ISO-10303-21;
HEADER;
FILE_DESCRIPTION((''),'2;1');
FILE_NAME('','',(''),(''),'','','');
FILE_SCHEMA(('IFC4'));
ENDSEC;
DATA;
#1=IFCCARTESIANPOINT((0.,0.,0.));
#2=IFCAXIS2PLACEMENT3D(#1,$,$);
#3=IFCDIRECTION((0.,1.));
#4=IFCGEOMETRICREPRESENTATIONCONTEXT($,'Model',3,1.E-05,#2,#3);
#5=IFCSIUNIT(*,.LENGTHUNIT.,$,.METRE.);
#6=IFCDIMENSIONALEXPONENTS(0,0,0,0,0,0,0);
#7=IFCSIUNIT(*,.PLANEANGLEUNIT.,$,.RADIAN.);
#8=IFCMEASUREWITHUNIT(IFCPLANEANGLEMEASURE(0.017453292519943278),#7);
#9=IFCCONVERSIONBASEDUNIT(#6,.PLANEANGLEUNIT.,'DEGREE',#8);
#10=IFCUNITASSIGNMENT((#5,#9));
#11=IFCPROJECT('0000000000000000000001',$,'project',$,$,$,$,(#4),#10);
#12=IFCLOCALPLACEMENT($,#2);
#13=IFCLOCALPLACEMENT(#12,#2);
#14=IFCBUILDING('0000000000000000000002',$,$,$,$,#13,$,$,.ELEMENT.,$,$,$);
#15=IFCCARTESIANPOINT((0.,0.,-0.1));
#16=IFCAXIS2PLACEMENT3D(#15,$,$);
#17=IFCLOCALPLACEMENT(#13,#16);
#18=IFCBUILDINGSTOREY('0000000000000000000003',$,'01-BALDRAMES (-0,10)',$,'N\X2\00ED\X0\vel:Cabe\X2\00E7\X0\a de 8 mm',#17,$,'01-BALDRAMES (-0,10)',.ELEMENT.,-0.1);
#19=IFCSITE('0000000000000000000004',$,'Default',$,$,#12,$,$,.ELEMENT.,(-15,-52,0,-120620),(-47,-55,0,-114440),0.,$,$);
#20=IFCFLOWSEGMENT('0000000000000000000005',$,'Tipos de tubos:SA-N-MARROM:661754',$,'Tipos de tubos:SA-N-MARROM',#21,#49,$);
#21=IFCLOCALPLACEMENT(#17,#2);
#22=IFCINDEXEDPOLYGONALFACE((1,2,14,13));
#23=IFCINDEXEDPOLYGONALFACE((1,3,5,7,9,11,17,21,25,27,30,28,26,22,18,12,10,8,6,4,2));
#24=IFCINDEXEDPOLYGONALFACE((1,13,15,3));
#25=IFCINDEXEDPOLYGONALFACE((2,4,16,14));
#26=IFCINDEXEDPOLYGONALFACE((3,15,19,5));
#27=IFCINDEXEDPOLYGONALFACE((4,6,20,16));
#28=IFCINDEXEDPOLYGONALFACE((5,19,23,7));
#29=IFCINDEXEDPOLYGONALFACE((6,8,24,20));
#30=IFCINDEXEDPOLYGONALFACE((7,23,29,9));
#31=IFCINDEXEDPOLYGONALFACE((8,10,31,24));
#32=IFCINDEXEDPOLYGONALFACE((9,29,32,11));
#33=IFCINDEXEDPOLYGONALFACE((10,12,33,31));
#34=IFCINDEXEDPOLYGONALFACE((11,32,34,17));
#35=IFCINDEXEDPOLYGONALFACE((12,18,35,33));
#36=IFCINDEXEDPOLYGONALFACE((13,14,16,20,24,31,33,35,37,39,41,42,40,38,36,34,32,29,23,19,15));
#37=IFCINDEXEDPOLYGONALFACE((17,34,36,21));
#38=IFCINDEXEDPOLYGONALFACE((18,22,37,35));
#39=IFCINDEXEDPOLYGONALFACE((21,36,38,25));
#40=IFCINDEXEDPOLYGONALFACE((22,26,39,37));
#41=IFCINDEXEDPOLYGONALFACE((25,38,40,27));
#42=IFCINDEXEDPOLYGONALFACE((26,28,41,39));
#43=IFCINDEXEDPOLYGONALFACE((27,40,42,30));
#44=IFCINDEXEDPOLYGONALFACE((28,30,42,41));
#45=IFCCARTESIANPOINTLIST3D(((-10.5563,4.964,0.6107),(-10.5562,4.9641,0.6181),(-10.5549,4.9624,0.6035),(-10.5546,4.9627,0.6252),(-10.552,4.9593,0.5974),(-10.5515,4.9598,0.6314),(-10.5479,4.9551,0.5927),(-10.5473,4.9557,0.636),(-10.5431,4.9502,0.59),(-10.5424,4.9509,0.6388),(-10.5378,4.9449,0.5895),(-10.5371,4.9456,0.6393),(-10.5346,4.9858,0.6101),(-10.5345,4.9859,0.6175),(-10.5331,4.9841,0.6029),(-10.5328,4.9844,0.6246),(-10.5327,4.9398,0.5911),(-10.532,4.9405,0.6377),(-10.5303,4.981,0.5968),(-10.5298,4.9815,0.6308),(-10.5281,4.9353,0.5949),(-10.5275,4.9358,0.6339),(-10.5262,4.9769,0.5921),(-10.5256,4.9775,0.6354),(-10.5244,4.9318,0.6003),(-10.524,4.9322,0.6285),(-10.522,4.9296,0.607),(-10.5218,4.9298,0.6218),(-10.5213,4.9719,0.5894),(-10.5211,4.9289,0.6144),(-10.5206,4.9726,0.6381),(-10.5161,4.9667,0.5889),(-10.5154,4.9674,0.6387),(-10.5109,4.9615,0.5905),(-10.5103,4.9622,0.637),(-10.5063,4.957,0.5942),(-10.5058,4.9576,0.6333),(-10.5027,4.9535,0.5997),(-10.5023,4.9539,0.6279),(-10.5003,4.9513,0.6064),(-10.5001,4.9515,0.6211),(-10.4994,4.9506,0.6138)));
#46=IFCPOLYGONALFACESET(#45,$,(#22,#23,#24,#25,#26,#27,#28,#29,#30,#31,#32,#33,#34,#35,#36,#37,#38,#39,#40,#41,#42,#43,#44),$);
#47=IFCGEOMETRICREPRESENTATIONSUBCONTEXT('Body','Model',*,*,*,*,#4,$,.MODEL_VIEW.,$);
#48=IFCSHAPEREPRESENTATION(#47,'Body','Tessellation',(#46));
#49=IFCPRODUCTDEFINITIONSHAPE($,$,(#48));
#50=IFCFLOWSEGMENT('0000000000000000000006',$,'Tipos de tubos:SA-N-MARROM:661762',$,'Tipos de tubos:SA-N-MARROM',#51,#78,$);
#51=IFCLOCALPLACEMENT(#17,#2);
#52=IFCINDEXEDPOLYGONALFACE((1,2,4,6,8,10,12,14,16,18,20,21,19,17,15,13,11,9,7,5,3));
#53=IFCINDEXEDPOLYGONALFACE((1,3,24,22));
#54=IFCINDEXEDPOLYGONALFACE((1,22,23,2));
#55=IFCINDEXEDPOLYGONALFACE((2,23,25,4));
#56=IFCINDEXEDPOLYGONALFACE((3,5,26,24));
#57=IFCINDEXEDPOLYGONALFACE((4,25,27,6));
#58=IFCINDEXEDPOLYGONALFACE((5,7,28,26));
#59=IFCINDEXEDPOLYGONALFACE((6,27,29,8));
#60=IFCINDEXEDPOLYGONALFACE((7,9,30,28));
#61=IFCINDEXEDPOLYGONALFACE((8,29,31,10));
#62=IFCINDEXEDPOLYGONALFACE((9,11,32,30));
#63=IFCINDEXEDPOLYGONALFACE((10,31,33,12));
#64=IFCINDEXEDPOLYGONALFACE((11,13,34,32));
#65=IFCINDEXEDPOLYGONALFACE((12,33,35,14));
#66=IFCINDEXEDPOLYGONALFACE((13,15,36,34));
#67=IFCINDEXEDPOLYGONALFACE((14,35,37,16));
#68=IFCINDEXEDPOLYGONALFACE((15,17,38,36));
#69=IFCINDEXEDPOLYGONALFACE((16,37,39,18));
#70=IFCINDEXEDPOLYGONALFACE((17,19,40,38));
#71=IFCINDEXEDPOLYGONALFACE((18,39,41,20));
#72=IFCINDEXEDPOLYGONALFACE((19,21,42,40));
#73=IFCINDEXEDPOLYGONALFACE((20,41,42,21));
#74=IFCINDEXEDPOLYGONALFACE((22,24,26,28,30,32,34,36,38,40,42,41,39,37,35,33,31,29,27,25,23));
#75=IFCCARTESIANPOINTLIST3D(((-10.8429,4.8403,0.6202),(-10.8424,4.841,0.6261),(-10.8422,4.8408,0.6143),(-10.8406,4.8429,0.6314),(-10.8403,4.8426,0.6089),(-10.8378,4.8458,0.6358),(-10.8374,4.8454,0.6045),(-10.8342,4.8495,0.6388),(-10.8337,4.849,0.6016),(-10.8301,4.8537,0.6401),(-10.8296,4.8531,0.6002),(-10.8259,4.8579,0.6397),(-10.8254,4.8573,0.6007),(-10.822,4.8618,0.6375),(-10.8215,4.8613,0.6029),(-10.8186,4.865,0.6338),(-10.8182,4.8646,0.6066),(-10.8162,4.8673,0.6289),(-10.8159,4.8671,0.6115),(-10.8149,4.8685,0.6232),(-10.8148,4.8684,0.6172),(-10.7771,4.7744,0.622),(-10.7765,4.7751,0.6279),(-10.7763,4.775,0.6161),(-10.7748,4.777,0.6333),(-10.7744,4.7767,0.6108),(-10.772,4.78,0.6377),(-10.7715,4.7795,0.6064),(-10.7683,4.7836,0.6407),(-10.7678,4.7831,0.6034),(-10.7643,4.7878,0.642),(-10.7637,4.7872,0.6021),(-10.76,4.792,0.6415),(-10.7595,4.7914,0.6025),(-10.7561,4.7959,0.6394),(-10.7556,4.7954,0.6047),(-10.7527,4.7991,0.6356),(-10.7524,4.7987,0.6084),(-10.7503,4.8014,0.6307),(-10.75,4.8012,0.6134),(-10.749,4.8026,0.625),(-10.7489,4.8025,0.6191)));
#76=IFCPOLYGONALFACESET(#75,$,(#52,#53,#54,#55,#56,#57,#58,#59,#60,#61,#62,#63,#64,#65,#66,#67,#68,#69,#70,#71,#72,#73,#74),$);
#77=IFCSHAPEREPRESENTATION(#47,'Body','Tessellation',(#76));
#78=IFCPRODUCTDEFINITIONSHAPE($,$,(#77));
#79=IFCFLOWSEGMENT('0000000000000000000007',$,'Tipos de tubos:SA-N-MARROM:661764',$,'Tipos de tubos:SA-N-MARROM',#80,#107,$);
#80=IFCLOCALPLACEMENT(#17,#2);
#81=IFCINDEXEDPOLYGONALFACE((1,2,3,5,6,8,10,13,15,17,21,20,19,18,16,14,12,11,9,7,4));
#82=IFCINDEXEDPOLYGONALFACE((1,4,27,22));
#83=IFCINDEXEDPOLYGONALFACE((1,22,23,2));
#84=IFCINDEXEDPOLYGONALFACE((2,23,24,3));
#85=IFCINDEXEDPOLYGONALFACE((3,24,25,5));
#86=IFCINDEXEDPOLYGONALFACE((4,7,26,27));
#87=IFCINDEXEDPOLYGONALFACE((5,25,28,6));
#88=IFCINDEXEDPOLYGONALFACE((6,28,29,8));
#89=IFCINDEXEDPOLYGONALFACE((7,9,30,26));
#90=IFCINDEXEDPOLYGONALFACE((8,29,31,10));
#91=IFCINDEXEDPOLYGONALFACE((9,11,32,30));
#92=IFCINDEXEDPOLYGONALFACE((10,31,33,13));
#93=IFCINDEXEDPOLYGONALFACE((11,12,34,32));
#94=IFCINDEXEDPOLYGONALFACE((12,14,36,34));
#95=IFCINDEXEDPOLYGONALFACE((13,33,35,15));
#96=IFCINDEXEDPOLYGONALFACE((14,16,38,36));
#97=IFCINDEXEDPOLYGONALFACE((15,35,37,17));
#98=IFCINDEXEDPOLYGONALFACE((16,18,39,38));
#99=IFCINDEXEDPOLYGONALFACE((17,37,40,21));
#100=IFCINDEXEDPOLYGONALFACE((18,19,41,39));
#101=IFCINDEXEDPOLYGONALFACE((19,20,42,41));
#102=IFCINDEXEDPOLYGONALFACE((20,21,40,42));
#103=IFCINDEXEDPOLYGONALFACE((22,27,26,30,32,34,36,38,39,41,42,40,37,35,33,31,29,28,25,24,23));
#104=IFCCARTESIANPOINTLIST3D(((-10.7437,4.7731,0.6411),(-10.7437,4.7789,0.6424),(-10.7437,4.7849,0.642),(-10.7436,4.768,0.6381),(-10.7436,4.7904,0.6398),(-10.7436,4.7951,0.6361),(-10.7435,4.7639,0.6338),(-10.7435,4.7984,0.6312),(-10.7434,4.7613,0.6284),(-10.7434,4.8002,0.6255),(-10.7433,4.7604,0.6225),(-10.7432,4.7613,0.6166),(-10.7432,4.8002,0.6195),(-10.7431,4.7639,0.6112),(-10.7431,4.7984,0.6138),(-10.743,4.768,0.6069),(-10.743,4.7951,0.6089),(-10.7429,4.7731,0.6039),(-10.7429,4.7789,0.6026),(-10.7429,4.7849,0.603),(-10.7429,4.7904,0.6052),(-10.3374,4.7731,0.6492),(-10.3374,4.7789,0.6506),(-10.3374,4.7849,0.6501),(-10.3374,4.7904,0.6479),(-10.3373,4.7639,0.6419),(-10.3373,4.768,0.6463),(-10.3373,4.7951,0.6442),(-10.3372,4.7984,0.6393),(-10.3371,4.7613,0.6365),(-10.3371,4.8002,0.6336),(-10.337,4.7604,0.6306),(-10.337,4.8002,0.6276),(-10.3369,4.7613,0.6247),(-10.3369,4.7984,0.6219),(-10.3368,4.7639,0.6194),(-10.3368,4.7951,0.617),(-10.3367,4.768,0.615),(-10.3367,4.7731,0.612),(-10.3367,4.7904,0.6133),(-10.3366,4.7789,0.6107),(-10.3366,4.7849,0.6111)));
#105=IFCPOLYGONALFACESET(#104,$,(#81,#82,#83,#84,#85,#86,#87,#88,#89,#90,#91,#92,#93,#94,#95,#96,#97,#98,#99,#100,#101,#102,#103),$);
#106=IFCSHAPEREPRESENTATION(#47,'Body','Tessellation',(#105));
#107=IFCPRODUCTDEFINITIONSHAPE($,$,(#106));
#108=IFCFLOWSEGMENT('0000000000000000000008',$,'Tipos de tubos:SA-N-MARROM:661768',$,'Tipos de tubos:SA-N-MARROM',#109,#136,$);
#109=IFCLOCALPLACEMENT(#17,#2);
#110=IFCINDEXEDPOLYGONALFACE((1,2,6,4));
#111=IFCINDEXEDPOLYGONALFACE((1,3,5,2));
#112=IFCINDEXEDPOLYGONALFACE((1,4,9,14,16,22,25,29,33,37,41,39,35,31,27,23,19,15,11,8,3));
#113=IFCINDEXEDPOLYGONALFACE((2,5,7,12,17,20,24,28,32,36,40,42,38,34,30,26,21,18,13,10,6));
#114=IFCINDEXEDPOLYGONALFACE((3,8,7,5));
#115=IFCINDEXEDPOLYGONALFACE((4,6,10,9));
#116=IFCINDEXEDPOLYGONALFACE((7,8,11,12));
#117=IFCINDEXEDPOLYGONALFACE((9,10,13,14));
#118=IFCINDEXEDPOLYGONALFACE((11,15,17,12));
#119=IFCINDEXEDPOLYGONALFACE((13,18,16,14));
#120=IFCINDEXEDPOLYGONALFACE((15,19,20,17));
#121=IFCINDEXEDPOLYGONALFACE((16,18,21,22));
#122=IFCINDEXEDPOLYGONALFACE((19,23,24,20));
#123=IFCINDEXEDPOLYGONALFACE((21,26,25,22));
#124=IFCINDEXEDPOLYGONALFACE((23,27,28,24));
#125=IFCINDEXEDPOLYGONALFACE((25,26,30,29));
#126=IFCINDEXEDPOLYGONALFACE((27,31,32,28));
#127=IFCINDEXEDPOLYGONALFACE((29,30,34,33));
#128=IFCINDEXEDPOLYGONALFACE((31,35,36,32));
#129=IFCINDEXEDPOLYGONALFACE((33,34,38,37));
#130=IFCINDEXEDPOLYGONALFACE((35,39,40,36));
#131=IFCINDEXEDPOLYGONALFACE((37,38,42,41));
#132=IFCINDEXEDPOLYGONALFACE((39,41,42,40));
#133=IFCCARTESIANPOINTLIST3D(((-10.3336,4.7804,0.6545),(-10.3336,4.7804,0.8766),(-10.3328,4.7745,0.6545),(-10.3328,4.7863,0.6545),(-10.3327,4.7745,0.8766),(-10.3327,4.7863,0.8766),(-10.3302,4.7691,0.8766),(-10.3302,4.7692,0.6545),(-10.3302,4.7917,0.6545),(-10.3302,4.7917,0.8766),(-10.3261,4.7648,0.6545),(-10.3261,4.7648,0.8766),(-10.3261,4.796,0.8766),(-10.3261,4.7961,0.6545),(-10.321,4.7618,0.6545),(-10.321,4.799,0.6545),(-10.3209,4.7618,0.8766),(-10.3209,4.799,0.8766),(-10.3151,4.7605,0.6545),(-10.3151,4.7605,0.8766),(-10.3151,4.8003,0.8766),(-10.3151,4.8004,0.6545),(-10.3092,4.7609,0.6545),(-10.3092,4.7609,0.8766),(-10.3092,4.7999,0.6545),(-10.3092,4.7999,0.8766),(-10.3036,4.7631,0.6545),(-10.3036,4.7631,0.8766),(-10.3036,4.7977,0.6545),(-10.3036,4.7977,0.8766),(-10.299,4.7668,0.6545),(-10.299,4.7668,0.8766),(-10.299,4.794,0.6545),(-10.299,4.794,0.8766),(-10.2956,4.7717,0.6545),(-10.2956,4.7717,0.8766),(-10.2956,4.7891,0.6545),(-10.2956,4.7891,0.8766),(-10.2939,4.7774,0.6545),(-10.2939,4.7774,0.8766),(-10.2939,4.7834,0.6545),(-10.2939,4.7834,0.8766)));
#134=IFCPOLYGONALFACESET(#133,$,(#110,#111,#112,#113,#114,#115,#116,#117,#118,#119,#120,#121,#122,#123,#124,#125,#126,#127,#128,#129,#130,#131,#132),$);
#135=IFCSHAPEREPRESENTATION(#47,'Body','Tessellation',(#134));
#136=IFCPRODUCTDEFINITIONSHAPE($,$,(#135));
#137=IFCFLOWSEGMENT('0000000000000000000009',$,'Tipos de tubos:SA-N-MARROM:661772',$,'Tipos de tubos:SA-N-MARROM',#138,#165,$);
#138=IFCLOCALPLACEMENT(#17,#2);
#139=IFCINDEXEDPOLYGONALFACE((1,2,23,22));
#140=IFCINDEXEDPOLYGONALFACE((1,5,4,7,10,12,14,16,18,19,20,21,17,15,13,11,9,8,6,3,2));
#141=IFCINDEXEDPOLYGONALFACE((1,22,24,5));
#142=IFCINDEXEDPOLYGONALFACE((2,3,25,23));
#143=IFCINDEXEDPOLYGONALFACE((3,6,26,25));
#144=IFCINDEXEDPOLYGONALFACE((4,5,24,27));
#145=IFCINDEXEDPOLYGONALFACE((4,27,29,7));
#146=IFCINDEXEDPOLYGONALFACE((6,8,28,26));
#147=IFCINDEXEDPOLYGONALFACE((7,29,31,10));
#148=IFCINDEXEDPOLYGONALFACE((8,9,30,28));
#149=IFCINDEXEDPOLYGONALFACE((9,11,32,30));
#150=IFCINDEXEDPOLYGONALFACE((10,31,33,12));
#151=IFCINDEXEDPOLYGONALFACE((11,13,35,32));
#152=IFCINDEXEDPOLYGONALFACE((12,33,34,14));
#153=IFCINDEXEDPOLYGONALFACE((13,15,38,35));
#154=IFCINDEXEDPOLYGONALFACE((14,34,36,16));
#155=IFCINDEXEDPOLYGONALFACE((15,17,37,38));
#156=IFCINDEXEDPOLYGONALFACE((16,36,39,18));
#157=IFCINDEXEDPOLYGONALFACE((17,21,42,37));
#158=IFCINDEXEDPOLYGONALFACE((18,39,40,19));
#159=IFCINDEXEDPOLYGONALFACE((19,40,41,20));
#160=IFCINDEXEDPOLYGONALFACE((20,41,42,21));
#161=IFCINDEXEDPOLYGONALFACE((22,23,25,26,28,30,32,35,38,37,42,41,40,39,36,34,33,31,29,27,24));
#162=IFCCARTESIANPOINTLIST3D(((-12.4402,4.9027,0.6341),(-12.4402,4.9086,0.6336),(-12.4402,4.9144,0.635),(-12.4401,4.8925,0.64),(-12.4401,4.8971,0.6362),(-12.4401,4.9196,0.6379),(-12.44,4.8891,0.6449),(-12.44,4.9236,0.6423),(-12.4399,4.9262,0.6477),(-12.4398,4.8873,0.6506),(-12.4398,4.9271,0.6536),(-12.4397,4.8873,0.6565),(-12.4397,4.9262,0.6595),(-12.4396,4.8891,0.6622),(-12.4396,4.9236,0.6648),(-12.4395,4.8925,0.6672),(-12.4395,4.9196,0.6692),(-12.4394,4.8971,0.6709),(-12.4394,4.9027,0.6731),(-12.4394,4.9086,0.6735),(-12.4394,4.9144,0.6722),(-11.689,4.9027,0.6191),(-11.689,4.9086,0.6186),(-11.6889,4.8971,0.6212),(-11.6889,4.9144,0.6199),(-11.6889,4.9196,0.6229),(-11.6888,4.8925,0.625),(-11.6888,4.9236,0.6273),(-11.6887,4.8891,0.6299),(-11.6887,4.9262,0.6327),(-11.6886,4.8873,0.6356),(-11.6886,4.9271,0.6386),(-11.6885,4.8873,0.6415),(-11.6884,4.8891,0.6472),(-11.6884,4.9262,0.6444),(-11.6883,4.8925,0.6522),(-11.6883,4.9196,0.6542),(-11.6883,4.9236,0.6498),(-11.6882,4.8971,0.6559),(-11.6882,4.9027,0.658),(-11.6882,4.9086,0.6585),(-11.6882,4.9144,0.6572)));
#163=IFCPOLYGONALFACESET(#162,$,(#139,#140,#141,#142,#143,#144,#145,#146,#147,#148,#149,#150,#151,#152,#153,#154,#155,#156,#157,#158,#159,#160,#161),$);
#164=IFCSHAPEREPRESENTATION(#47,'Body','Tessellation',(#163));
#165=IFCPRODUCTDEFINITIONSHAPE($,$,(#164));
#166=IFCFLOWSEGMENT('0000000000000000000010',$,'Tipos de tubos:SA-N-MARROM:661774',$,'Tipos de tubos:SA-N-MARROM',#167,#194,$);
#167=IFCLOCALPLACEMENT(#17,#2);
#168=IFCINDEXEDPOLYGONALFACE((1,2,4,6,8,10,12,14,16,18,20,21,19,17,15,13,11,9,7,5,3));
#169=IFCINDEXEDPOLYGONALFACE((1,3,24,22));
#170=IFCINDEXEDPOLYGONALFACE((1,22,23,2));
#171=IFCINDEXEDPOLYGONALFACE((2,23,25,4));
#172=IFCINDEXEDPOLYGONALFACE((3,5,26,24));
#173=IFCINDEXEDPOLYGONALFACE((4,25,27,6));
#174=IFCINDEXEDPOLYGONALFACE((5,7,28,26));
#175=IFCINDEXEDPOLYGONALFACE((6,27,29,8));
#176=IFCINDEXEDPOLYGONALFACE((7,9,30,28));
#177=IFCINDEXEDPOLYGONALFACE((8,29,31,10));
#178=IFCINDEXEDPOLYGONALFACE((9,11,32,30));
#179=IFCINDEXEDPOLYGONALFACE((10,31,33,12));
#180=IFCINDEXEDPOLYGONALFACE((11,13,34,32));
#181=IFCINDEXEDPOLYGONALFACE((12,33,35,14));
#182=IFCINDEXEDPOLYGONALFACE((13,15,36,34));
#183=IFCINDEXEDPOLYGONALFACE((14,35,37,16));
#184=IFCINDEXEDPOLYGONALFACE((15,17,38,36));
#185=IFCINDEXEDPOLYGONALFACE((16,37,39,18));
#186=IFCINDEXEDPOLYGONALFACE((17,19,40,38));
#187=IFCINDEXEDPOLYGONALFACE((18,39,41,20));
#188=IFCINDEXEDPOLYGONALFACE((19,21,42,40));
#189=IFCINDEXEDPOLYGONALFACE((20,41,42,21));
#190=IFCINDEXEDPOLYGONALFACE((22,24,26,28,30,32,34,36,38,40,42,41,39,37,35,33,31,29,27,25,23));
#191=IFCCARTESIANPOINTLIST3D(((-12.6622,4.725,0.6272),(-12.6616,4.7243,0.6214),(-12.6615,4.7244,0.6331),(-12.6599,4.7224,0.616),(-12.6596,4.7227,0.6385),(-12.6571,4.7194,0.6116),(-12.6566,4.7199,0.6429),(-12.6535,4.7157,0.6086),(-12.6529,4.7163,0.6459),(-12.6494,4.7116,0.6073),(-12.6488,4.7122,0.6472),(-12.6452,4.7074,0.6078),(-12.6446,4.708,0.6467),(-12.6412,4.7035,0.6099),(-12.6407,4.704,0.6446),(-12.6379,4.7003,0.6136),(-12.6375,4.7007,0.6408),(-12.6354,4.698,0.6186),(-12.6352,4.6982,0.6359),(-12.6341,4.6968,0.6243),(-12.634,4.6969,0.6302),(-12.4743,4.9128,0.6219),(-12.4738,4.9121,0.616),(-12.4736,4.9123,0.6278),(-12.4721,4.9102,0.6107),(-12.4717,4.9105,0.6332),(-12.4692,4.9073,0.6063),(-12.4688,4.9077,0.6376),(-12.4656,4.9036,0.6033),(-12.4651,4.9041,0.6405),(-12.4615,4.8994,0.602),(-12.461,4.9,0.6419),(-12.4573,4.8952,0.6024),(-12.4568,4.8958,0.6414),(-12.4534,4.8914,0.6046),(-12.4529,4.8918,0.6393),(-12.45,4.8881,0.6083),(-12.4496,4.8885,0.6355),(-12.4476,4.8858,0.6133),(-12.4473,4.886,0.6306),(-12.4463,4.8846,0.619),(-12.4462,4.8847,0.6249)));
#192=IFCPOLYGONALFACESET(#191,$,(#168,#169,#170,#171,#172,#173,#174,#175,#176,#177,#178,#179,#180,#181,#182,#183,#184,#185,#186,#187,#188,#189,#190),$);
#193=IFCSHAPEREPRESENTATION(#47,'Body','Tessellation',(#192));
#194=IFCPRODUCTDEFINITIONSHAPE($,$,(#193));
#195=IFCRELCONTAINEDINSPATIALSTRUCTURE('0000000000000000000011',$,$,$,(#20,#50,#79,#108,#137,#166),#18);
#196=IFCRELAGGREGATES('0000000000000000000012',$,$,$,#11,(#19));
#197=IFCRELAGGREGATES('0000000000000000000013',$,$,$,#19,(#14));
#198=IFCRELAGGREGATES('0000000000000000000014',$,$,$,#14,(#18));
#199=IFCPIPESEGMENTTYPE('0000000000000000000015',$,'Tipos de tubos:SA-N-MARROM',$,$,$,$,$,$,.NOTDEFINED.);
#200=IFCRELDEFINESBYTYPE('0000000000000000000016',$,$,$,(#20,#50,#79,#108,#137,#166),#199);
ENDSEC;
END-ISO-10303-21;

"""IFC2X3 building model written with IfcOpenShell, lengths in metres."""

from ifc_helpers import new_model, entity, si_unit, converted_unit, direction, frame, frame_2d, origin, origin_2d_with_axis, place, context, subcontext, project, spatial, circle, extrude, type_object, element, save


model = new_model("IFC2X3")

# Units and contexts
model_context = context("Model", 3, precision=1e-05, world=origin(), true_north=direction((0.0, 1.0)))
body_context = subcontext(model_context, "Body", "Model", "MODEL_VIEW")
ifc_project = project(units=[si_unit("LENGTHUNIT", "METRE"), converted_unit("PLANEANGLEUNIT", "DEGREE", entity("IfcPlaneAngleMeasure", 0.017453292519943278), si_unit("PLANEANGLEUNIT", "RADIAN"), dimensions=[0, 0, 0, 0, 0, 0, 0])], contexts=[model_context])

# Site, building, storey
site_placement = place(None, origin())
site = spatial("IfcSite", under=ifc_project, at=site_placement, Name="Default", CompositionType="ELEMENT", RefLatitude=(-15, -52, 0, -120620), RefLongitude=(-47, -55, 0, -114440), RefElevation=0.0)
building_placement = place(site_placement, origin())
building = spatial("IfcBuilding", under=site, at=building_placement, CompositionType="ELEMENT")
storey_placement = place(building_placement, frame((0.0, 0.0, -0.1)))
storey = spatial("IfcBuildingStorey", under=building, at=storey_placement, Name="01-BALDRAMES (-0,10)", ObjectType="Nível:Cabeça de 8 mm", LongName="01-BALDRAMES (-0,10)", CompositionType="ELEMENT", Elevation=-0.1)

# Flow segments
pipe_segment_type_1 = type_object("IfcPipeSegmentType", Name="Tipos de tubos:SA-N-MARROM", PredefinedType="NOTDEFINED")
flow_segment_1_placement = place(storey_placement, origin())
element("IfcFlowSegment", 1, at=flow_segment_1_placement, inside=storey, type_object=pipe_segment_type_1, Name="Tipos de tubos:SA-N-MARROM:661754", ObjectType="Tipos de tubos:SA-N-MARROM", context=body_context, shape_type="SweptSolid", body=[
    extrude(circle(Radius=0.025, at=frame_2d((0.0, 0.0), x_axis=(1.0, 0.0))), frame((-10.5388, 4.9466, 0.6144), z_axis=(0.706965, 0.706966, -0.019996), x_axis=(0.707107, -0.707106, 0.0)), (0.0, 0.0, 1.0), 0.0307),
])
flow_segment_2_placement = place(storey_placement, origin())
element("IfcFlowSegment", 2, at=flow_segment_2_placement, inside=storey, type_object=pipe_segment_type_1, Name="Tipos de tubos:SA-N-MARROM:661762", ObjectType="Tipos de tubos:SA-N-MARROM", context=body_context, shape_type="SweptSolid", body=[
    extrude(circle(Radius=0.02, at=origin_2d_with_axis()), frame((-10.8288, 4.8544, 0.6202), z_axis=(0.706966, -0.706965, 0.019996), x_axis=(-0.707106, -0.707107, 0.0)), (0.0, 0.0, 1.0), 0.0932),
])
flow_segment_3_placement = place(storey_placement, origin())
element("IfcFlowSegment", 3, at=flow_segment_3_placement, inside=storey, type_object=pipe_segment_type_1, Name="Tipos de tubos:SA-N-MARROM:661764", ObjectType="Tipos de tubos:SA-N-MARROM", context=body_context, shape_type="SweptSolid", body=[
    extrude(circle(Radius=0.02, at=frame_2d((0.0, 0.0), x_axis=(1.0, 0.0))), frame((-10.7433, 4.7804, 0.6225), z_axis=(0.9998, 0.000001, 0.019996), x_axis=(0.000001, -1.0, 0.0)), (0.0, 0.0, 1.0), 0.4063),
])
flow_segment_4_placement = place(storey_placement, origin())
element("IfcFlowSegment", 4, at=flow_segment_4_placement, inside=storey, type_object=pipe_segment_type_1, Name="Tipos de tubos:SA-N-MARROM:661768", ObjectType="Tipos de tubos:SA-N-MARROM", context=body_context, shape_type="SweptSolid", body=[
    extrude(circle(Radius=0.02, at=frame_2d((0.0, 0.0), x_axis=(1.0, 0.0))), frame((-10.3136, 4.7804, 0.6545), z_axis=(0.00005, -0.000071, 1.0), x_axis=(-1.0, 0.0, 0.00005)), (0.0, 0.0, 1.0), 0.2221),
])
flow_segment_5_placement = place(storey_placement, origin())
element("IfcFlowSegment", 5, at=flow_segment_5_placement, inside=storey, type_object=pipe_segment_type_1, Name="Tipos de tubos:SA-N-MARROM:661772", ObjectType="Tipos de tubos:SA-N-MARROM", context=body_context, shape_type="SweptSolid", body=[
    extrude(circle(Radius=0.02, at=origin_2d_with_axis()), frame((-12.4398, 4.9071, 0.6536), z_axis=(0.9998, 0.000001, -0.019977), x_axis=(-0.000001, 1.0, 0.0)), (0.0, 0.0, 1.0), 0.7514),
])
flow_segment_6_placement = place(storey_placement, origin())
element("IfcFlowSegment", 6, at=flow_segment_6_placement, inside=storey, type_object=pipe_segment_type_1, Name="Tipos de tubos:SA-N-MARROM:661774", ObjectType="Tipos de tubos:SA-N-MARROM", context=body_context, shape_type="SweptSolid", body=[
    extrude(circle(Radius=0.02, at=origin_2d_with_axis()), frame((-12.648, 4.7108, 0.6272), z_axis=(0.706965, 0.706966, -0.019996), x_axis=(-0.707107, 0.707106, 0.0)), (0.0, 0.0, 1.0), 0.2657),
])

save(model, "model.ifc")
